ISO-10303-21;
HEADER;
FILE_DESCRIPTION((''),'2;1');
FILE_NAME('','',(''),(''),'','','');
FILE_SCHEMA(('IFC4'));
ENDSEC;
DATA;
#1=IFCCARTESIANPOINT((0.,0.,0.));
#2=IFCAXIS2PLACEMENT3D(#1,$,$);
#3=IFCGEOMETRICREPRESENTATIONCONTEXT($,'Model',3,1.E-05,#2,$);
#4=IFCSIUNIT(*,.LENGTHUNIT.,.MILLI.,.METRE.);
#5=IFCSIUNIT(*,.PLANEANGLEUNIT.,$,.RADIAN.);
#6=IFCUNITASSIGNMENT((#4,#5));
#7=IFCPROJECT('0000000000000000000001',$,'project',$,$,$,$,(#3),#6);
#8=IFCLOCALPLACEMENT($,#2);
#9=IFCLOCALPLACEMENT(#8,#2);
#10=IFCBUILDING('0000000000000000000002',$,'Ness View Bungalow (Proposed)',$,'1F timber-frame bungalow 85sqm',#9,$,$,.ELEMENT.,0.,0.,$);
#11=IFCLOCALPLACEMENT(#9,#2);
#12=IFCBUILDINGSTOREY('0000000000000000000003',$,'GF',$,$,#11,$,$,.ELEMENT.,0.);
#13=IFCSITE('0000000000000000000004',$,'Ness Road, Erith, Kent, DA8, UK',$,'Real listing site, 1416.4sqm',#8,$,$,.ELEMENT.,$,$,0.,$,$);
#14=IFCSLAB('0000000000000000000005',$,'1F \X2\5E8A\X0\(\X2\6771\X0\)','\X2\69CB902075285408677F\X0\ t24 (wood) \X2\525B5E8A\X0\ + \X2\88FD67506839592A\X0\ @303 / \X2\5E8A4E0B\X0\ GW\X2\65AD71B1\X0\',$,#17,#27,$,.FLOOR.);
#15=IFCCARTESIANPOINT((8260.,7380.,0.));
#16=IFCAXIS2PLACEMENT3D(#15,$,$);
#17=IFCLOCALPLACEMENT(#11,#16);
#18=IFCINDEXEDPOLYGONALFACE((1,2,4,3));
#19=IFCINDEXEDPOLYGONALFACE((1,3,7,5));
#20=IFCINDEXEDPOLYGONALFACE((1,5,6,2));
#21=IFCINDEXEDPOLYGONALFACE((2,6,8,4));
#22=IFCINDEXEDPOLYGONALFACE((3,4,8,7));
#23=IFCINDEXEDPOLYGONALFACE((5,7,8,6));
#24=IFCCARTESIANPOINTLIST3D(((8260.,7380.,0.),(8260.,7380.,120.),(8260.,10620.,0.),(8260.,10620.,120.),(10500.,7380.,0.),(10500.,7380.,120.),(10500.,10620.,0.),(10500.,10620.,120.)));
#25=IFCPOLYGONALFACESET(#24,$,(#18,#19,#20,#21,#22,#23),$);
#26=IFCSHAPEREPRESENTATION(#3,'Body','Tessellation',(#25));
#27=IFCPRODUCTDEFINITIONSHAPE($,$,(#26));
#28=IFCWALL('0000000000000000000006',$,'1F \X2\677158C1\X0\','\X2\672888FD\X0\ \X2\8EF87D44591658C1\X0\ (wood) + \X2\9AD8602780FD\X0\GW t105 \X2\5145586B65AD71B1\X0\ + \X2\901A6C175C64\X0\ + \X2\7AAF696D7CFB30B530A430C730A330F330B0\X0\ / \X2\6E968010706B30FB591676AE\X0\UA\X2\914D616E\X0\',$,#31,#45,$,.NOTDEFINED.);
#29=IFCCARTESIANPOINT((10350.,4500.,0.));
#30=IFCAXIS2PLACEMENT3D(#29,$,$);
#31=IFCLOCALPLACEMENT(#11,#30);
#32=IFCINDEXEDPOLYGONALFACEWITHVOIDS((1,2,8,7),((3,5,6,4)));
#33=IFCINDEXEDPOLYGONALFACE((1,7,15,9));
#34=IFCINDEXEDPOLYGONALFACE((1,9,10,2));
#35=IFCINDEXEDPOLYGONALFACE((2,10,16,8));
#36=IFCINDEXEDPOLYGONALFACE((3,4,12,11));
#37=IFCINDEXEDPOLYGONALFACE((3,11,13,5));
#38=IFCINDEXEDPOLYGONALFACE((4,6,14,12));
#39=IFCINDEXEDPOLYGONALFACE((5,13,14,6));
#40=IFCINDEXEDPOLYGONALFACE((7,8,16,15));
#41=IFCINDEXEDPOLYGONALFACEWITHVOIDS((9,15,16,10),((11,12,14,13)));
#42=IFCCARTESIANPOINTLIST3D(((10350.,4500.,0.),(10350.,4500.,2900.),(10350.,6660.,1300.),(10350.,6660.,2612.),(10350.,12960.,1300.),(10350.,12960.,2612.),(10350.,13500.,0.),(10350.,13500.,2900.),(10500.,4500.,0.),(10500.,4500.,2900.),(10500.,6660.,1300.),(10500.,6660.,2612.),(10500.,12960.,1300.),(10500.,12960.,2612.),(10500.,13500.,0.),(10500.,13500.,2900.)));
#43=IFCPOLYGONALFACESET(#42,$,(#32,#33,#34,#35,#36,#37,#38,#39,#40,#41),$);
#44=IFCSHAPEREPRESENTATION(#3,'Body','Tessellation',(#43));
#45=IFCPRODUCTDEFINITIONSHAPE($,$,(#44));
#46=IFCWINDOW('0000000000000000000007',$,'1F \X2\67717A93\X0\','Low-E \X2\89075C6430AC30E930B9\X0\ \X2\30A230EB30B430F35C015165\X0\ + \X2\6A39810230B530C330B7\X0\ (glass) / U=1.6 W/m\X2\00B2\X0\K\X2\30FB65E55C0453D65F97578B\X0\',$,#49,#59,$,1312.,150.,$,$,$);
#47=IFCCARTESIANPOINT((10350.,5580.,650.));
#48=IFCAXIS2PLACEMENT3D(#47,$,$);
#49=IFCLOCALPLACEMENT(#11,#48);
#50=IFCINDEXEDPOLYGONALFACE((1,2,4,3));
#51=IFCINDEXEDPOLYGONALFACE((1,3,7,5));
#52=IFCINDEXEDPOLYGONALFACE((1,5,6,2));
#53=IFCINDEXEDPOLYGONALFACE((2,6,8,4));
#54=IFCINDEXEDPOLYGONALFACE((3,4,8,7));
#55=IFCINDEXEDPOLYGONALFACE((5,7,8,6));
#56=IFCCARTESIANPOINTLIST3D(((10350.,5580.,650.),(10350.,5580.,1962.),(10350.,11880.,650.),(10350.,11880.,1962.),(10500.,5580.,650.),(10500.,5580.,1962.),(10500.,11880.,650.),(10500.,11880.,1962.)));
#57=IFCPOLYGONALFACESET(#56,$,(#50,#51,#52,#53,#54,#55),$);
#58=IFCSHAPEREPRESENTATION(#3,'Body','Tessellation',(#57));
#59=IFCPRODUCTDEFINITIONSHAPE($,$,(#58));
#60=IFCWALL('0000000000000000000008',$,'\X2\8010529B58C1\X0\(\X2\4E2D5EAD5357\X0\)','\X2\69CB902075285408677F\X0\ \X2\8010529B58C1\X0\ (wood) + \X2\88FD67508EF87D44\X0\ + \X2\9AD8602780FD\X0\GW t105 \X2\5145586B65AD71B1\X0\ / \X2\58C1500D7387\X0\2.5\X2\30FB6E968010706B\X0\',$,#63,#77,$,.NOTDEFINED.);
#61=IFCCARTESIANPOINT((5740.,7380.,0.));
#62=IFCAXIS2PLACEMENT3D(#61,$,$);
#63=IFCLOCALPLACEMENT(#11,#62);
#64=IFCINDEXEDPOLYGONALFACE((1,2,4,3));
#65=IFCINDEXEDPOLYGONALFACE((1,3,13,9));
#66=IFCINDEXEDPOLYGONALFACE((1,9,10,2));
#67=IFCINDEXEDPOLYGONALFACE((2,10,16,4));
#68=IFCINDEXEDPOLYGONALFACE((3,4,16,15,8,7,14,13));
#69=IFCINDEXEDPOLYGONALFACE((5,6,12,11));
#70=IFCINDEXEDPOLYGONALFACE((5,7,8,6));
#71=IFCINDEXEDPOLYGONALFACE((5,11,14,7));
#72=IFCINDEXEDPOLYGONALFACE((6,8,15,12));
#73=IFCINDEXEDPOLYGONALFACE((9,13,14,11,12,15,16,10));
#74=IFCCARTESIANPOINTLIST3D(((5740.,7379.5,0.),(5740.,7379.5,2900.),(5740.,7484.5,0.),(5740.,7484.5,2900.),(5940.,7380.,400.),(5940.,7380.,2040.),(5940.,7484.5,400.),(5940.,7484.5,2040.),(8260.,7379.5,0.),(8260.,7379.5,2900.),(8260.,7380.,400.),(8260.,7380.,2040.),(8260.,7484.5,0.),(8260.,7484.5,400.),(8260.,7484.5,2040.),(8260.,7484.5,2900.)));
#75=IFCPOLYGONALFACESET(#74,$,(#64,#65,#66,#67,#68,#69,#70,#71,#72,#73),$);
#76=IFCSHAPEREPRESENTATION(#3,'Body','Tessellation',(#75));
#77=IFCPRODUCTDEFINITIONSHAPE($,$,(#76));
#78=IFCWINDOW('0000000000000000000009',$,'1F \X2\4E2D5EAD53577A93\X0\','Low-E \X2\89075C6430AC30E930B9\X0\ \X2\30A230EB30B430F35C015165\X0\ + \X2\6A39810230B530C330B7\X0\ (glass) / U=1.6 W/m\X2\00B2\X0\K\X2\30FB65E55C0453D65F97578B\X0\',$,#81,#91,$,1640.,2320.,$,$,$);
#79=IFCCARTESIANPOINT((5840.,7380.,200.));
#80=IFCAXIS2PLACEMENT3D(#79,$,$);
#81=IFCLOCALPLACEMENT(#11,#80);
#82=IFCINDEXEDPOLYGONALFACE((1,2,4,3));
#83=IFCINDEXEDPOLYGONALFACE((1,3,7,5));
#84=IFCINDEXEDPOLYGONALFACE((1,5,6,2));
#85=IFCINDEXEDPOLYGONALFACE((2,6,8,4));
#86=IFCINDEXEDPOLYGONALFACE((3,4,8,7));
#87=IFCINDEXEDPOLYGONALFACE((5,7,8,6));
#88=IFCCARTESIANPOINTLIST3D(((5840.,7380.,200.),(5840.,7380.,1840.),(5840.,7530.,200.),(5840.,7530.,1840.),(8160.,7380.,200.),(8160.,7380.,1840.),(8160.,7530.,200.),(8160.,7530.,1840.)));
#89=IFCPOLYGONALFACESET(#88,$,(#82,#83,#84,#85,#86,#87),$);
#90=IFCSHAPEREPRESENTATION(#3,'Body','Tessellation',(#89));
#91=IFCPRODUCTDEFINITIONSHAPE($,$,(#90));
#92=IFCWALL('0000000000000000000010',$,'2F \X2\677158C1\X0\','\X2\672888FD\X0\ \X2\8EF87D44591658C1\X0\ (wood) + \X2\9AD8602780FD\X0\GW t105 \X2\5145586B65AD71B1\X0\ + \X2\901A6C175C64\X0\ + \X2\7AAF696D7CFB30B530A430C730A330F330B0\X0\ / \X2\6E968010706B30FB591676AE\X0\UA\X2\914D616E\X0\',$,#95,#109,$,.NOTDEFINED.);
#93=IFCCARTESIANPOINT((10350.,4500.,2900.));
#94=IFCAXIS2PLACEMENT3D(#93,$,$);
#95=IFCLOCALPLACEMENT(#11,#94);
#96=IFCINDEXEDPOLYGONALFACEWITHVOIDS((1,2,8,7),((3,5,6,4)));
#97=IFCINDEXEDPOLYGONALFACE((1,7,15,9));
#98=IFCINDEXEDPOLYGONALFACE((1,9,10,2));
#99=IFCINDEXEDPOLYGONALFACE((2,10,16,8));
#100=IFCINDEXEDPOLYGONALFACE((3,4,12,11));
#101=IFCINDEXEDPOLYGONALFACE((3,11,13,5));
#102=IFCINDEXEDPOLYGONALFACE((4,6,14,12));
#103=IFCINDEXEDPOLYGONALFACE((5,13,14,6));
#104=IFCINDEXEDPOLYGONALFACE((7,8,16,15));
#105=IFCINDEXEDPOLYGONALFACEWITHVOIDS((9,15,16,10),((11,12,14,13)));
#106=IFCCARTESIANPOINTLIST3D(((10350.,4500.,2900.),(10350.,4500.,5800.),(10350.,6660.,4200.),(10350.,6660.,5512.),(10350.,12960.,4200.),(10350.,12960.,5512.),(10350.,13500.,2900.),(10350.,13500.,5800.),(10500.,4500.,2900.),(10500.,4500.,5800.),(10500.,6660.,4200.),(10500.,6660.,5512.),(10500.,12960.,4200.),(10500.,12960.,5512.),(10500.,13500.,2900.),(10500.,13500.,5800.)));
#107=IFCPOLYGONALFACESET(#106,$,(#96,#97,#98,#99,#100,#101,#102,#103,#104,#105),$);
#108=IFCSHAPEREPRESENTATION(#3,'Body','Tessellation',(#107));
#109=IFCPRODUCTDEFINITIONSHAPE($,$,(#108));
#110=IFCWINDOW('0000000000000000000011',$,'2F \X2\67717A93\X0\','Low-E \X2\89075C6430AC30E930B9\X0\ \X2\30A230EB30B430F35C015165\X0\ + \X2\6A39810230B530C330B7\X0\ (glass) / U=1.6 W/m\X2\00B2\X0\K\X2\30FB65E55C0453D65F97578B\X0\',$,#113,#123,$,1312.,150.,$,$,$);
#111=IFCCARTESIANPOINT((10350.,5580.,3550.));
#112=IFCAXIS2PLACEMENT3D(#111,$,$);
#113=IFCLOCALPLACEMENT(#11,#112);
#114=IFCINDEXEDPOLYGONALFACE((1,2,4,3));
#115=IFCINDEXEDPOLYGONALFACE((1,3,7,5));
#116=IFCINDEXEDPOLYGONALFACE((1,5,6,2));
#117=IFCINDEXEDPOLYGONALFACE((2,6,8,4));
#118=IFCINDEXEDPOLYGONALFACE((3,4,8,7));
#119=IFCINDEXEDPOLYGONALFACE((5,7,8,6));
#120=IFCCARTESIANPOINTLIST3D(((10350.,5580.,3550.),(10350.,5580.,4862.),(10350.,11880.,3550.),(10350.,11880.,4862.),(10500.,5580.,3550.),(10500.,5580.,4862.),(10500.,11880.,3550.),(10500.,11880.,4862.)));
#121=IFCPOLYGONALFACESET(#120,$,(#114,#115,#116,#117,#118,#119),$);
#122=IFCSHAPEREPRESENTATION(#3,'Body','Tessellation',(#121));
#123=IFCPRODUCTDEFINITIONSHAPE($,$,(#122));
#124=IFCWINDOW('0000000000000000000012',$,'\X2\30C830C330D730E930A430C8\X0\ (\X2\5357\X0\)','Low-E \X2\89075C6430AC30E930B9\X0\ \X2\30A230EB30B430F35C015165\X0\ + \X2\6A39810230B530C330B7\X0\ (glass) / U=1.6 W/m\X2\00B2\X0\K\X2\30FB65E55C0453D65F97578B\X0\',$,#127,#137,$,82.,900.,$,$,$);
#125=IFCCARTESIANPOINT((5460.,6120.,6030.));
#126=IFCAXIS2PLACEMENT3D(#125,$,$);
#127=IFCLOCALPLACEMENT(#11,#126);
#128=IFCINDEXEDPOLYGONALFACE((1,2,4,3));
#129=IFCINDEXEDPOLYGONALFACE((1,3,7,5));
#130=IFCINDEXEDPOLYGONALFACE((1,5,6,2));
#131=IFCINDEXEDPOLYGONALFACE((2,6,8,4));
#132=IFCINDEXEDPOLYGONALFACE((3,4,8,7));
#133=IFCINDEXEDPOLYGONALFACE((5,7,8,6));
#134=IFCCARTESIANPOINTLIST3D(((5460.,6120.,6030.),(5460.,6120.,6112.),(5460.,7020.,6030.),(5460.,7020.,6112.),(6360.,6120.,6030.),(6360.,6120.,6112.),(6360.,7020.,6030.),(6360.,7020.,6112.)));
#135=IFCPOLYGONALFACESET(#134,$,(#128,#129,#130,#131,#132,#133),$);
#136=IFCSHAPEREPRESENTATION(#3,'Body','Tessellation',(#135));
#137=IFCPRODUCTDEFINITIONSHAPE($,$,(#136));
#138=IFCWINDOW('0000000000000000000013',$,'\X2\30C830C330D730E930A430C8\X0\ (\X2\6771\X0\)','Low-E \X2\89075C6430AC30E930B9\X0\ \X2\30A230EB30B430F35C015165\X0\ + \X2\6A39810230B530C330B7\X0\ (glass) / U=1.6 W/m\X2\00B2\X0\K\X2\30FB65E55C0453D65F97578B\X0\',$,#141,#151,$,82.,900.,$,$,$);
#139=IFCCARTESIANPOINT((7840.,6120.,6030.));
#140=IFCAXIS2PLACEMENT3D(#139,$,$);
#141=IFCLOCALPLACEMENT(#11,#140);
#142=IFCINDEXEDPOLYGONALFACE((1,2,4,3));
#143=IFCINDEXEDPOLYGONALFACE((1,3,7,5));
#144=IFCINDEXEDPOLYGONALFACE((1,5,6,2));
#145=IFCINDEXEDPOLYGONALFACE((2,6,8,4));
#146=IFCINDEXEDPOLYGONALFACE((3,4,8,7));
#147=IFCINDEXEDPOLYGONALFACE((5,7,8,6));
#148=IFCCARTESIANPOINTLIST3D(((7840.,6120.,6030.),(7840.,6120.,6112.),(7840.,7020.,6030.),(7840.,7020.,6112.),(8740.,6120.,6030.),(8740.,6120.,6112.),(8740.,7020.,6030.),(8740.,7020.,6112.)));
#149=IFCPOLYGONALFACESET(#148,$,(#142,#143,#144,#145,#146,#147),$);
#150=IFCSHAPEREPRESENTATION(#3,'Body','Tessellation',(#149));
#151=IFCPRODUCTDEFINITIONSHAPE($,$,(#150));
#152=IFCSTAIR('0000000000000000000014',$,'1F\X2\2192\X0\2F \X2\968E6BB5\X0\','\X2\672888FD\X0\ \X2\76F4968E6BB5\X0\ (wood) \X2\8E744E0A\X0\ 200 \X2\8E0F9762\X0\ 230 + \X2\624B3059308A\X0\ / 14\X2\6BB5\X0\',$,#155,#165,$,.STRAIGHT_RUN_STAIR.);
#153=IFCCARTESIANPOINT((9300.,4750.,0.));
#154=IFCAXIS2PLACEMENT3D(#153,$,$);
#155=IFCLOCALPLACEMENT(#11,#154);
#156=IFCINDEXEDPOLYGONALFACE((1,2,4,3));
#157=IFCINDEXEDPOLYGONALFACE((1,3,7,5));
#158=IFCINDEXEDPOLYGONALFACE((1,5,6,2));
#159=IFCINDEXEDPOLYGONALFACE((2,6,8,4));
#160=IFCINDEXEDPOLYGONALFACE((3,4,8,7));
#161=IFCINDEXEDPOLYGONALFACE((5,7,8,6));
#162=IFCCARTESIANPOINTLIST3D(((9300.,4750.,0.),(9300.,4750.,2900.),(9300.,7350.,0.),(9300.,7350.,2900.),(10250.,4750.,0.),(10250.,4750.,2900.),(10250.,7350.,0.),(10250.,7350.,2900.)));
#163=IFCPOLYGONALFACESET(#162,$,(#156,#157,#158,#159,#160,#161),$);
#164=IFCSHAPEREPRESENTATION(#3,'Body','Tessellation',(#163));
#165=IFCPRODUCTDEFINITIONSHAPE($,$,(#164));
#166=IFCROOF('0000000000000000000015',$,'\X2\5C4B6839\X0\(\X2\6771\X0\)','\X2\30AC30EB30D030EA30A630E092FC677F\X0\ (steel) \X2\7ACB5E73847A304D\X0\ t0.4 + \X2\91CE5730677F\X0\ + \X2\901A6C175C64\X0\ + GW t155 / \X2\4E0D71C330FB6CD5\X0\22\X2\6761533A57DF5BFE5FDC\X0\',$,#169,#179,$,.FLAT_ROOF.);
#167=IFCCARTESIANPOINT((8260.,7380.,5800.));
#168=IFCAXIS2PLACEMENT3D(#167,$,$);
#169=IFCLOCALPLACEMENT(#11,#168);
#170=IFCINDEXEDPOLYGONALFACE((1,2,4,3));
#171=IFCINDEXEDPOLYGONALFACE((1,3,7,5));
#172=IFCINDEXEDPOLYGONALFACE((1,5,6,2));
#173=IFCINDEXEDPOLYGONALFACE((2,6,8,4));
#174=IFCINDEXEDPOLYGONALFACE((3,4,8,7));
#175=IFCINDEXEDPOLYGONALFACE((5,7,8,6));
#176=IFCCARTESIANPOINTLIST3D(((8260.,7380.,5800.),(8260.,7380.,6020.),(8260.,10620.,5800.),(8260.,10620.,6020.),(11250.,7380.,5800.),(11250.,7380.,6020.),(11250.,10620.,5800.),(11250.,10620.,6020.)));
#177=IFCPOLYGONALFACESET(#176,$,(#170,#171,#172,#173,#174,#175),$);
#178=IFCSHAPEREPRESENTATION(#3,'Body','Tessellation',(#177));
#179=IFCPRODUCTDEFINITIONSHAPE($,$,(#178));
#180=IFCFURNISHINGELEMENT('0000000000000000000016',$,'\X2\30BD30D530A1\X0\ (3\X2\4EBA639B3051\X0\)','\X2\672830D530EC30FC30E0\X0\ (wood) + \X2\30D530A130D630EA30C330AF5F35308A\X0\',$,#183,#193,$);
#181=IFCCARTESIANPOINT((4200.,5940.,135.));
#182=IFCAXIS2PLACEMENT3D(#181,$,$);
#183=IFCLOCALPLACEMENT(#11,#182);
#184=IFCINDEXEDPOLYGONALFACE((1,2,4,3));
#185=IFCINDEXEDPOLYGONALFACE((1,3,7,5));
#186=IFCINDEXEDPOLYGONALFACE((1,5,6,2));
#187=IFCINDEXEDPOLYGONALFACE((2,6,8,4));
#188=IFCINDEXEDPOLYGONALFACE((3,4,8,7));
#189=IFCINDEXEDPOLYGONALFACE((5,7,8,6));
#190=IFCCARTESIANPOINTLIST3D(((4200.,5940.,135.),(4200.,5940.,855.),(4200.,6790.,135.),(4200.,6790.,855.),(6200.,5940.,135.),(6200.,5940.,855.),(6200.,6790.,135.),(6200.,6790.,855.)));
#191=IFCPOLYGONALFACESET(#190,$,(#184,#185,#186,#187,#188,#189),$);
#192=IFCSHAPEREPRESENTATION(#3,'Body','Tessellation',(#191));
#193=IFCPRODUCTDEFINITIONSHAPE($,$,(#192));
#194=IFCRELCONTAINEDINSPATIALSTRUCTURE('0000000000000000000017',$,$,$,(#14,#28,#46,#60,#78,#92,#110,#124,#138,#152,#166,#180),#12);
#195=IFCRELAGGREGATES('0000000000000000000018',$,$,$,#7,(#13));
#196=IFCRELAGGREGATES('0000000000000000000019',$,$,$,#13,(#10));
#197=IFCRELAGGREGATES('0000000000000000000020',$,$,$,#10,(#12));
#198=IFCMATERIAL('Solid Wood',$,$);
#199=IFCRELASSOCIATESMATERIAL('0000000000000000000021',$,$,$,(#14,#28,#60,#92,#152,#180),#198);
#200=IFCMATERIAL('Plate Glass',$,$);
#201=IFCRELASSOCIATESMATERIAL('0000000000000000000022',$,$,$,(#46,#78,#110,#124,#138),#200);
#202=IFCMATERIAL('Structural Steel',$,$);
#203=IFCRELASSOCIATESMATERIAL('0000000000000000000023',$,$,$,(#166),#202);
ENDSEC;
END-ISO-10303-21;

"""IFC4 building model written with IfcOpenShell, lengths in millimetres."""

from ifc_helpers import new_model, si_unit, frame, frame_2d, origin, place, context, project, spatial, rectangle, extrude, material, element, fill, save


model = new_model("IFC4")

# Units and contexts
model_context = context("Model", 3, precision=1e-05, world=origin())
ifc_project = project(units=[si_unit("LENGTHUNIT", "METRE", prefix="MILLI"), si_unit("PLANEANGLEUNIT", "RADIAN")], contexts=[model_context])

# Site, building, storey
site_placement = place(None, origin())
site = spatial("IfcSite", under=ifc_project, at=site_placement, Name="Ness Road, Erith, Kent, DA8, UK", ObjectType="Real listing site, 1416.4sqm", CompositionType="ELEMENT", RefElevation=0.0)
building_placement = place(site_placement, origin())
building = spatial("IfcBuilding", under=site, at=building_placement, Name="Ness View Bungalow (Proposed)", ObjectType="1F timber-frame bungalow 85sqm", CompositionType="ELEMENT", ElevationOfRefHeight=0.0, ElevationOfTerrain=0.0)
storey_placement = place(building_placement, origin())
storey = spatial("IfcBuildingStorey", under=building, at=storey_placement, Name="GF", CompositionType="ELEMENT", Elevation=0.0)

# Slab
ifc_material_1 = material(Name="Solid Wood")
slab_placement = place(storey_placement, frame((8260.0, 7380.0, 0.0)))
element("IfcSlab", 1, at=slab_placement, inside=storey, material=ifc_material_1, Name="1F 床(東)", Description="構造用合板 t24 (wood) 剛床 + 製材根太 @303 / 床下 GW断熱", PredefinedType="FLOOR", context=model_context, shape_type="SweptSolid", body=[
    extrude(rectangle(XDim=2240.0, YDim=3240.0, at=frame_2d((1120.0, 1620.0))), frame((8260.0, 7380.0, 0.0)), (0.0, 0.0, 1.0), 120.0),
])

# Walls, openings, windows
wall_1_placement = place(storey_placement, frame((10350.0, 4500.0, 0.0)))
wall_1 = element("IfcWall", 2, at=wall_1_placement, inside=storey, material=ifc_material_1, Name="1F 東壁", Description="木製 軸組外壁 (wood) + 高性能GW t105 充填断熱 + 通気層 + 窯業系サイディング / 準耐火・外皮UA配慮", PredefinedType="NOTDEFINED", context=model_context, shape_type="SweptSolid", body=[
    extrude(rectangle(XDim=150.0, YDim=9000.0, at=frame_2d((75.0, 4500.0))), frame((10350.0, 4500.0, 0.0)), (0.0, 0.0, 1.0), 2900.0),
])
opening_1_placement = place(storey_placement, frame((10350.0, 5580.0, 650.0)))
opening_1 = element("IfcOpeningElement", 3, at=opening_1_placement, cuts=wall_1, PredefinedType="NOTDEFINED", context=model_context, shape_type="SweptSolid", body=[
    extrude(rectangle(XDim=150.0, YDim=6300.0, at=frame_2d((75.0, 3150.0))), frame((10350.0, 5580.0, 650.0)), (0.0, 0.0, 1.0), 1312.0),
])
ifc_material_2 = material(Name="Plate Glass")
window_1_placement = place(storey_placement, frame((10350.0, 5580.0, 650.0)))
window_1 = element("IfcWindow", 4, at=window_1_placement, inside=storey, material=ifc_material_2, Name="1F 東窓", Description="Low-E 複層ガラス アルゴン封入 + 樹脂サッシ (glass) / U=1.6 W/m²K・日射取得型", OverallHeight=1312.0, OverallWidth=150.0, context=model_context, shape_type="SweptSolid", body=[
    extrude(rectangle(XDim=150.0, YDim=6300.0, at=frame_2d((75.0, 3150.0))), frame((10350.0, 5580.0, 650.0)), (0.0, 0.0, 1.0), 1312.0),
])
fill(opening_1, window_1)
wall_2_placement = place(storey_placement, frame((5740.0, 7380.0, 0.0)))
wall_2 = element("IfcWall", 5, at=wall_2_placement, inside=storey, material=ifc_material_1, Name="耐力壁(中庭南)", Description="構造用合板 耐力壁 (wood) + 製材軸組 + 高性能GW t105 充填断熱 / 壁倍率2.5・準耐火", PredefinedType="NOTDEFINED", context=model_context, shape_type="SweptSolid", body=[
    extrude(rectangle(XDim=2520.0, YDim=105.0, at=frame_2d((1260.0, 52.0))), frame((5740.0, 7380.0, 0.0)), (0.0, 0.0, 1.0), 2900.0),
])
opening_2_placement = place(storey_placement, frame((5840.0, 7380.0, 200.0)))
opening_2 = element("IfcOpeningElement", 6, at=opening_2_placement, cuts=wall_2, PredefinedType="NOTDEFINED", context=model_context, shape_type="SweptSolid", body=[
    extrude(rectangle(XDim=2320.0, YDim=150.0, at=frame_2d((1160.0, 75.0))), frame((5840.0, 7380.0, 200.0)), (0.0, 0.0, 1.0), 1640.0),
])
window_2_placement = place(storey_placement, frame((5840.0, 7380.0, 200.0)))
window_2 = element("IfcWindow", 7, at=window_2_placement, inside=storey, material=ifc_material_2, Name="1F 中庭南窓", Description="Low-E 複層ガラス アルゴン封入 + 樹脂サッシ (glass) / U=1.6 W/m²K・日射取得型", OverallHeight=1640.0, OverallWidth=2320.0, context=model_context, shape_type="SweptSolid", body=[
    extrude(rectangle(XDim=2320.0, YDim=150.0, at=frame_2d((1160.0, 75.0))), frame((5840.0, 7380.0, 200.0)), (0.0, 0.0, 1.0), 1640.0),
])
fill(opening_2, window_2)

# Wall, opening, window
wall_3_placement = place(storey_placement, frame((10350.0, 4500.0, 2900.0)))
wall_3 = element("IfcWall", 8, at=wall_3_placement, inside=storey, material=ifc_material_1, Name="2F 東壁", Description="木製 軸組外壁 (wood) + 高性能GW t105 充填断熱 + 通気層 + 窯業系サイディング / 準耐火・外皮UA配慮", PredefinedType="NOTDEFINED", context=model_context, shape_type="SweptSolid", body=[
    extrude(rectangle(XDim=150.0, YDim=9000.0, at=frame_2d((75.0, 4500.0))), frame((10350.0, 4500.0, 2900.0)), (0.0, 0.0, 1.0), 2900.0),
])
opening_3_placement = place(storey_placement, frame((10350.0, 5580.0, 3550.0)))
opening_3 = element("IfcOpeningElement", 9, at=opening_3_placement, cuts=wall_3, PredefinedType="NOTDEFINED", context=model_context, shape_type="SweptSolid", body=[
    extrude(rectangle(XDim=150.0, YDim=6300.0, at=frame_2d((75.0, 3150.0))), frame((10350.0, 5580.0, 3550.0)), (0.0, 0.0, 1.0), 1312.0),
])
window_3_placement = place(storey_placement, frame((10350.0, 5580.0, 3550.0)))
window_3 = element("IfcWindow", 10, at=window_3_placement, inside=storey, material=ifc_material_2, Name="2F 東窓", Description="Low-E 複層ガラス アルゴン封入 + 樹脂サッシ (glass) / U=1.6 W/m²K・日射取得型", OverallHeight=1312.0, OverallWidth=150.0, context=model_context, shape_type="SweptSolid", body=[
    extrude(rectangle(XDim=150.0, YDim=6300.0, at=frame_2d((75.0, 3150.0))), frame((10350.0, 5580.0, 3550.0)), (0.0, 0.0, 1.0), 1312.0),
])
fill(opening_3, window_3)

# Windows
window_4_placement = place(storey_placement, frame((5460.0, 6120.0, 6030.0)))
element("IfcWindow", 11, at=window_4_placement, inside=storey, material=ifc_material_2, Name="トップライト (南)", Description="Low-E 複層ガラス アルゴン封入 + 樹脂サッシ (glass) / U=1.6 W/m²K・日射取得型", OverallHeight=82.0, OverallWidth=900.0, context=model_context, shape_type="SweptSolid", body=[
    extrude(rectangle(XDim=900.0, YDim=900.0, at=frame_2d((450.0, 450.0))), frame((5460.0, 6120.0, 6030.0)), (0.0, 0.0, 1.0), 82.0),
])
window_5_placement = place(storey_placement, frame((7840.0, 6120.0, 6030.0)))
element("IfcWindow", 12, at=window_5_placement, inside=storey, material=ifc_material_2, Name="トップライト (東)", Description="Low-E 複層ガラス アルゴン封入 + 樹脂サッシ (glass) / U=1.6 W/m²K・日射取得型", OverallHeight=82.0, OverallWidth=900.0, context=model_context, shape_type="SweptSolid", body=[
    extrude(rectangle(XDim=900.0, YDim=900.0, at=frame_2d((450.0, 450.0))), frame((7840.0, 6120.0, 6030.0)), (0.0, 0.0, 1.0), 82.0),
])

# Stair
stair_placement = place(storey_placement, frame((9300.0, 4750.0, 0.0)))
element("IfcStair", 13, at=stair_placement, inside=storey, material=ifc_material_1, Name="1F→2F 階段", Description="木製 直階段 (wood) 蹴上 200 踏面 230 + 手すり / 14段", PredefinedType="STRAIGHT_RUN_STAIR", context=model_context, shape_type="SweptSolid", body=[
    extrude(rectangle(XDim=950.0, YDim=2600.0, at=frame_2d((475.0, 1300.0))), frame((9300.0, 4750.0, 0.0)), (0.0, 0.0, 1.0), 2900.0),
])

# Roof
ifc_material_3 = material(Name="Structural Steel")
roof_placement = place(storey_placement, frame((8260.0, 7380.0, 5800.0)))
element("IfcRoof", 14, at=roof_placement, inside=storey, material=ifc_material_3, Name="屋根(東)", Description="ガルバリウム鋼板 (steel) 立平葺き t0.4 + 野地板 + 通気層 + GW t155 / 不燃・法22条区域対応", PredefinedType="FLAT_ROOF", context=model_context, shape_type="SweptSolid", body=[
    extrude(rectangle(XDim=2990.0, YDim=3240.0, at=frame_2d((1495.0, 1620.0))), frame((8260.0, 7380.0, 5800.0)), (0.0, 0.0, 1.0), 220.0),
])

# Furnishing element
furnishing_1_placement = place(storey_placement, frame((4200.0, 5940.0, 135.0)))
element("IfcFurnishingElement", 15, at=furnishing_1_placement, inside=storey, material=ifc_material_1, Name="ソファ (3人掛け)", Description="木フレーム (wood) + ファブリック張り", context=model_context, shape_type="SweptSolid", body=[
    extrude(rectangle(XDim=2000.0, YDim=850.0, at=frame_2d((1000.0, 425.0))), frame((4200.0, 5940.0, 135.0)), (0.0, 0.0, 1.0), 720.0),
])

save(model, "model.ifc")
